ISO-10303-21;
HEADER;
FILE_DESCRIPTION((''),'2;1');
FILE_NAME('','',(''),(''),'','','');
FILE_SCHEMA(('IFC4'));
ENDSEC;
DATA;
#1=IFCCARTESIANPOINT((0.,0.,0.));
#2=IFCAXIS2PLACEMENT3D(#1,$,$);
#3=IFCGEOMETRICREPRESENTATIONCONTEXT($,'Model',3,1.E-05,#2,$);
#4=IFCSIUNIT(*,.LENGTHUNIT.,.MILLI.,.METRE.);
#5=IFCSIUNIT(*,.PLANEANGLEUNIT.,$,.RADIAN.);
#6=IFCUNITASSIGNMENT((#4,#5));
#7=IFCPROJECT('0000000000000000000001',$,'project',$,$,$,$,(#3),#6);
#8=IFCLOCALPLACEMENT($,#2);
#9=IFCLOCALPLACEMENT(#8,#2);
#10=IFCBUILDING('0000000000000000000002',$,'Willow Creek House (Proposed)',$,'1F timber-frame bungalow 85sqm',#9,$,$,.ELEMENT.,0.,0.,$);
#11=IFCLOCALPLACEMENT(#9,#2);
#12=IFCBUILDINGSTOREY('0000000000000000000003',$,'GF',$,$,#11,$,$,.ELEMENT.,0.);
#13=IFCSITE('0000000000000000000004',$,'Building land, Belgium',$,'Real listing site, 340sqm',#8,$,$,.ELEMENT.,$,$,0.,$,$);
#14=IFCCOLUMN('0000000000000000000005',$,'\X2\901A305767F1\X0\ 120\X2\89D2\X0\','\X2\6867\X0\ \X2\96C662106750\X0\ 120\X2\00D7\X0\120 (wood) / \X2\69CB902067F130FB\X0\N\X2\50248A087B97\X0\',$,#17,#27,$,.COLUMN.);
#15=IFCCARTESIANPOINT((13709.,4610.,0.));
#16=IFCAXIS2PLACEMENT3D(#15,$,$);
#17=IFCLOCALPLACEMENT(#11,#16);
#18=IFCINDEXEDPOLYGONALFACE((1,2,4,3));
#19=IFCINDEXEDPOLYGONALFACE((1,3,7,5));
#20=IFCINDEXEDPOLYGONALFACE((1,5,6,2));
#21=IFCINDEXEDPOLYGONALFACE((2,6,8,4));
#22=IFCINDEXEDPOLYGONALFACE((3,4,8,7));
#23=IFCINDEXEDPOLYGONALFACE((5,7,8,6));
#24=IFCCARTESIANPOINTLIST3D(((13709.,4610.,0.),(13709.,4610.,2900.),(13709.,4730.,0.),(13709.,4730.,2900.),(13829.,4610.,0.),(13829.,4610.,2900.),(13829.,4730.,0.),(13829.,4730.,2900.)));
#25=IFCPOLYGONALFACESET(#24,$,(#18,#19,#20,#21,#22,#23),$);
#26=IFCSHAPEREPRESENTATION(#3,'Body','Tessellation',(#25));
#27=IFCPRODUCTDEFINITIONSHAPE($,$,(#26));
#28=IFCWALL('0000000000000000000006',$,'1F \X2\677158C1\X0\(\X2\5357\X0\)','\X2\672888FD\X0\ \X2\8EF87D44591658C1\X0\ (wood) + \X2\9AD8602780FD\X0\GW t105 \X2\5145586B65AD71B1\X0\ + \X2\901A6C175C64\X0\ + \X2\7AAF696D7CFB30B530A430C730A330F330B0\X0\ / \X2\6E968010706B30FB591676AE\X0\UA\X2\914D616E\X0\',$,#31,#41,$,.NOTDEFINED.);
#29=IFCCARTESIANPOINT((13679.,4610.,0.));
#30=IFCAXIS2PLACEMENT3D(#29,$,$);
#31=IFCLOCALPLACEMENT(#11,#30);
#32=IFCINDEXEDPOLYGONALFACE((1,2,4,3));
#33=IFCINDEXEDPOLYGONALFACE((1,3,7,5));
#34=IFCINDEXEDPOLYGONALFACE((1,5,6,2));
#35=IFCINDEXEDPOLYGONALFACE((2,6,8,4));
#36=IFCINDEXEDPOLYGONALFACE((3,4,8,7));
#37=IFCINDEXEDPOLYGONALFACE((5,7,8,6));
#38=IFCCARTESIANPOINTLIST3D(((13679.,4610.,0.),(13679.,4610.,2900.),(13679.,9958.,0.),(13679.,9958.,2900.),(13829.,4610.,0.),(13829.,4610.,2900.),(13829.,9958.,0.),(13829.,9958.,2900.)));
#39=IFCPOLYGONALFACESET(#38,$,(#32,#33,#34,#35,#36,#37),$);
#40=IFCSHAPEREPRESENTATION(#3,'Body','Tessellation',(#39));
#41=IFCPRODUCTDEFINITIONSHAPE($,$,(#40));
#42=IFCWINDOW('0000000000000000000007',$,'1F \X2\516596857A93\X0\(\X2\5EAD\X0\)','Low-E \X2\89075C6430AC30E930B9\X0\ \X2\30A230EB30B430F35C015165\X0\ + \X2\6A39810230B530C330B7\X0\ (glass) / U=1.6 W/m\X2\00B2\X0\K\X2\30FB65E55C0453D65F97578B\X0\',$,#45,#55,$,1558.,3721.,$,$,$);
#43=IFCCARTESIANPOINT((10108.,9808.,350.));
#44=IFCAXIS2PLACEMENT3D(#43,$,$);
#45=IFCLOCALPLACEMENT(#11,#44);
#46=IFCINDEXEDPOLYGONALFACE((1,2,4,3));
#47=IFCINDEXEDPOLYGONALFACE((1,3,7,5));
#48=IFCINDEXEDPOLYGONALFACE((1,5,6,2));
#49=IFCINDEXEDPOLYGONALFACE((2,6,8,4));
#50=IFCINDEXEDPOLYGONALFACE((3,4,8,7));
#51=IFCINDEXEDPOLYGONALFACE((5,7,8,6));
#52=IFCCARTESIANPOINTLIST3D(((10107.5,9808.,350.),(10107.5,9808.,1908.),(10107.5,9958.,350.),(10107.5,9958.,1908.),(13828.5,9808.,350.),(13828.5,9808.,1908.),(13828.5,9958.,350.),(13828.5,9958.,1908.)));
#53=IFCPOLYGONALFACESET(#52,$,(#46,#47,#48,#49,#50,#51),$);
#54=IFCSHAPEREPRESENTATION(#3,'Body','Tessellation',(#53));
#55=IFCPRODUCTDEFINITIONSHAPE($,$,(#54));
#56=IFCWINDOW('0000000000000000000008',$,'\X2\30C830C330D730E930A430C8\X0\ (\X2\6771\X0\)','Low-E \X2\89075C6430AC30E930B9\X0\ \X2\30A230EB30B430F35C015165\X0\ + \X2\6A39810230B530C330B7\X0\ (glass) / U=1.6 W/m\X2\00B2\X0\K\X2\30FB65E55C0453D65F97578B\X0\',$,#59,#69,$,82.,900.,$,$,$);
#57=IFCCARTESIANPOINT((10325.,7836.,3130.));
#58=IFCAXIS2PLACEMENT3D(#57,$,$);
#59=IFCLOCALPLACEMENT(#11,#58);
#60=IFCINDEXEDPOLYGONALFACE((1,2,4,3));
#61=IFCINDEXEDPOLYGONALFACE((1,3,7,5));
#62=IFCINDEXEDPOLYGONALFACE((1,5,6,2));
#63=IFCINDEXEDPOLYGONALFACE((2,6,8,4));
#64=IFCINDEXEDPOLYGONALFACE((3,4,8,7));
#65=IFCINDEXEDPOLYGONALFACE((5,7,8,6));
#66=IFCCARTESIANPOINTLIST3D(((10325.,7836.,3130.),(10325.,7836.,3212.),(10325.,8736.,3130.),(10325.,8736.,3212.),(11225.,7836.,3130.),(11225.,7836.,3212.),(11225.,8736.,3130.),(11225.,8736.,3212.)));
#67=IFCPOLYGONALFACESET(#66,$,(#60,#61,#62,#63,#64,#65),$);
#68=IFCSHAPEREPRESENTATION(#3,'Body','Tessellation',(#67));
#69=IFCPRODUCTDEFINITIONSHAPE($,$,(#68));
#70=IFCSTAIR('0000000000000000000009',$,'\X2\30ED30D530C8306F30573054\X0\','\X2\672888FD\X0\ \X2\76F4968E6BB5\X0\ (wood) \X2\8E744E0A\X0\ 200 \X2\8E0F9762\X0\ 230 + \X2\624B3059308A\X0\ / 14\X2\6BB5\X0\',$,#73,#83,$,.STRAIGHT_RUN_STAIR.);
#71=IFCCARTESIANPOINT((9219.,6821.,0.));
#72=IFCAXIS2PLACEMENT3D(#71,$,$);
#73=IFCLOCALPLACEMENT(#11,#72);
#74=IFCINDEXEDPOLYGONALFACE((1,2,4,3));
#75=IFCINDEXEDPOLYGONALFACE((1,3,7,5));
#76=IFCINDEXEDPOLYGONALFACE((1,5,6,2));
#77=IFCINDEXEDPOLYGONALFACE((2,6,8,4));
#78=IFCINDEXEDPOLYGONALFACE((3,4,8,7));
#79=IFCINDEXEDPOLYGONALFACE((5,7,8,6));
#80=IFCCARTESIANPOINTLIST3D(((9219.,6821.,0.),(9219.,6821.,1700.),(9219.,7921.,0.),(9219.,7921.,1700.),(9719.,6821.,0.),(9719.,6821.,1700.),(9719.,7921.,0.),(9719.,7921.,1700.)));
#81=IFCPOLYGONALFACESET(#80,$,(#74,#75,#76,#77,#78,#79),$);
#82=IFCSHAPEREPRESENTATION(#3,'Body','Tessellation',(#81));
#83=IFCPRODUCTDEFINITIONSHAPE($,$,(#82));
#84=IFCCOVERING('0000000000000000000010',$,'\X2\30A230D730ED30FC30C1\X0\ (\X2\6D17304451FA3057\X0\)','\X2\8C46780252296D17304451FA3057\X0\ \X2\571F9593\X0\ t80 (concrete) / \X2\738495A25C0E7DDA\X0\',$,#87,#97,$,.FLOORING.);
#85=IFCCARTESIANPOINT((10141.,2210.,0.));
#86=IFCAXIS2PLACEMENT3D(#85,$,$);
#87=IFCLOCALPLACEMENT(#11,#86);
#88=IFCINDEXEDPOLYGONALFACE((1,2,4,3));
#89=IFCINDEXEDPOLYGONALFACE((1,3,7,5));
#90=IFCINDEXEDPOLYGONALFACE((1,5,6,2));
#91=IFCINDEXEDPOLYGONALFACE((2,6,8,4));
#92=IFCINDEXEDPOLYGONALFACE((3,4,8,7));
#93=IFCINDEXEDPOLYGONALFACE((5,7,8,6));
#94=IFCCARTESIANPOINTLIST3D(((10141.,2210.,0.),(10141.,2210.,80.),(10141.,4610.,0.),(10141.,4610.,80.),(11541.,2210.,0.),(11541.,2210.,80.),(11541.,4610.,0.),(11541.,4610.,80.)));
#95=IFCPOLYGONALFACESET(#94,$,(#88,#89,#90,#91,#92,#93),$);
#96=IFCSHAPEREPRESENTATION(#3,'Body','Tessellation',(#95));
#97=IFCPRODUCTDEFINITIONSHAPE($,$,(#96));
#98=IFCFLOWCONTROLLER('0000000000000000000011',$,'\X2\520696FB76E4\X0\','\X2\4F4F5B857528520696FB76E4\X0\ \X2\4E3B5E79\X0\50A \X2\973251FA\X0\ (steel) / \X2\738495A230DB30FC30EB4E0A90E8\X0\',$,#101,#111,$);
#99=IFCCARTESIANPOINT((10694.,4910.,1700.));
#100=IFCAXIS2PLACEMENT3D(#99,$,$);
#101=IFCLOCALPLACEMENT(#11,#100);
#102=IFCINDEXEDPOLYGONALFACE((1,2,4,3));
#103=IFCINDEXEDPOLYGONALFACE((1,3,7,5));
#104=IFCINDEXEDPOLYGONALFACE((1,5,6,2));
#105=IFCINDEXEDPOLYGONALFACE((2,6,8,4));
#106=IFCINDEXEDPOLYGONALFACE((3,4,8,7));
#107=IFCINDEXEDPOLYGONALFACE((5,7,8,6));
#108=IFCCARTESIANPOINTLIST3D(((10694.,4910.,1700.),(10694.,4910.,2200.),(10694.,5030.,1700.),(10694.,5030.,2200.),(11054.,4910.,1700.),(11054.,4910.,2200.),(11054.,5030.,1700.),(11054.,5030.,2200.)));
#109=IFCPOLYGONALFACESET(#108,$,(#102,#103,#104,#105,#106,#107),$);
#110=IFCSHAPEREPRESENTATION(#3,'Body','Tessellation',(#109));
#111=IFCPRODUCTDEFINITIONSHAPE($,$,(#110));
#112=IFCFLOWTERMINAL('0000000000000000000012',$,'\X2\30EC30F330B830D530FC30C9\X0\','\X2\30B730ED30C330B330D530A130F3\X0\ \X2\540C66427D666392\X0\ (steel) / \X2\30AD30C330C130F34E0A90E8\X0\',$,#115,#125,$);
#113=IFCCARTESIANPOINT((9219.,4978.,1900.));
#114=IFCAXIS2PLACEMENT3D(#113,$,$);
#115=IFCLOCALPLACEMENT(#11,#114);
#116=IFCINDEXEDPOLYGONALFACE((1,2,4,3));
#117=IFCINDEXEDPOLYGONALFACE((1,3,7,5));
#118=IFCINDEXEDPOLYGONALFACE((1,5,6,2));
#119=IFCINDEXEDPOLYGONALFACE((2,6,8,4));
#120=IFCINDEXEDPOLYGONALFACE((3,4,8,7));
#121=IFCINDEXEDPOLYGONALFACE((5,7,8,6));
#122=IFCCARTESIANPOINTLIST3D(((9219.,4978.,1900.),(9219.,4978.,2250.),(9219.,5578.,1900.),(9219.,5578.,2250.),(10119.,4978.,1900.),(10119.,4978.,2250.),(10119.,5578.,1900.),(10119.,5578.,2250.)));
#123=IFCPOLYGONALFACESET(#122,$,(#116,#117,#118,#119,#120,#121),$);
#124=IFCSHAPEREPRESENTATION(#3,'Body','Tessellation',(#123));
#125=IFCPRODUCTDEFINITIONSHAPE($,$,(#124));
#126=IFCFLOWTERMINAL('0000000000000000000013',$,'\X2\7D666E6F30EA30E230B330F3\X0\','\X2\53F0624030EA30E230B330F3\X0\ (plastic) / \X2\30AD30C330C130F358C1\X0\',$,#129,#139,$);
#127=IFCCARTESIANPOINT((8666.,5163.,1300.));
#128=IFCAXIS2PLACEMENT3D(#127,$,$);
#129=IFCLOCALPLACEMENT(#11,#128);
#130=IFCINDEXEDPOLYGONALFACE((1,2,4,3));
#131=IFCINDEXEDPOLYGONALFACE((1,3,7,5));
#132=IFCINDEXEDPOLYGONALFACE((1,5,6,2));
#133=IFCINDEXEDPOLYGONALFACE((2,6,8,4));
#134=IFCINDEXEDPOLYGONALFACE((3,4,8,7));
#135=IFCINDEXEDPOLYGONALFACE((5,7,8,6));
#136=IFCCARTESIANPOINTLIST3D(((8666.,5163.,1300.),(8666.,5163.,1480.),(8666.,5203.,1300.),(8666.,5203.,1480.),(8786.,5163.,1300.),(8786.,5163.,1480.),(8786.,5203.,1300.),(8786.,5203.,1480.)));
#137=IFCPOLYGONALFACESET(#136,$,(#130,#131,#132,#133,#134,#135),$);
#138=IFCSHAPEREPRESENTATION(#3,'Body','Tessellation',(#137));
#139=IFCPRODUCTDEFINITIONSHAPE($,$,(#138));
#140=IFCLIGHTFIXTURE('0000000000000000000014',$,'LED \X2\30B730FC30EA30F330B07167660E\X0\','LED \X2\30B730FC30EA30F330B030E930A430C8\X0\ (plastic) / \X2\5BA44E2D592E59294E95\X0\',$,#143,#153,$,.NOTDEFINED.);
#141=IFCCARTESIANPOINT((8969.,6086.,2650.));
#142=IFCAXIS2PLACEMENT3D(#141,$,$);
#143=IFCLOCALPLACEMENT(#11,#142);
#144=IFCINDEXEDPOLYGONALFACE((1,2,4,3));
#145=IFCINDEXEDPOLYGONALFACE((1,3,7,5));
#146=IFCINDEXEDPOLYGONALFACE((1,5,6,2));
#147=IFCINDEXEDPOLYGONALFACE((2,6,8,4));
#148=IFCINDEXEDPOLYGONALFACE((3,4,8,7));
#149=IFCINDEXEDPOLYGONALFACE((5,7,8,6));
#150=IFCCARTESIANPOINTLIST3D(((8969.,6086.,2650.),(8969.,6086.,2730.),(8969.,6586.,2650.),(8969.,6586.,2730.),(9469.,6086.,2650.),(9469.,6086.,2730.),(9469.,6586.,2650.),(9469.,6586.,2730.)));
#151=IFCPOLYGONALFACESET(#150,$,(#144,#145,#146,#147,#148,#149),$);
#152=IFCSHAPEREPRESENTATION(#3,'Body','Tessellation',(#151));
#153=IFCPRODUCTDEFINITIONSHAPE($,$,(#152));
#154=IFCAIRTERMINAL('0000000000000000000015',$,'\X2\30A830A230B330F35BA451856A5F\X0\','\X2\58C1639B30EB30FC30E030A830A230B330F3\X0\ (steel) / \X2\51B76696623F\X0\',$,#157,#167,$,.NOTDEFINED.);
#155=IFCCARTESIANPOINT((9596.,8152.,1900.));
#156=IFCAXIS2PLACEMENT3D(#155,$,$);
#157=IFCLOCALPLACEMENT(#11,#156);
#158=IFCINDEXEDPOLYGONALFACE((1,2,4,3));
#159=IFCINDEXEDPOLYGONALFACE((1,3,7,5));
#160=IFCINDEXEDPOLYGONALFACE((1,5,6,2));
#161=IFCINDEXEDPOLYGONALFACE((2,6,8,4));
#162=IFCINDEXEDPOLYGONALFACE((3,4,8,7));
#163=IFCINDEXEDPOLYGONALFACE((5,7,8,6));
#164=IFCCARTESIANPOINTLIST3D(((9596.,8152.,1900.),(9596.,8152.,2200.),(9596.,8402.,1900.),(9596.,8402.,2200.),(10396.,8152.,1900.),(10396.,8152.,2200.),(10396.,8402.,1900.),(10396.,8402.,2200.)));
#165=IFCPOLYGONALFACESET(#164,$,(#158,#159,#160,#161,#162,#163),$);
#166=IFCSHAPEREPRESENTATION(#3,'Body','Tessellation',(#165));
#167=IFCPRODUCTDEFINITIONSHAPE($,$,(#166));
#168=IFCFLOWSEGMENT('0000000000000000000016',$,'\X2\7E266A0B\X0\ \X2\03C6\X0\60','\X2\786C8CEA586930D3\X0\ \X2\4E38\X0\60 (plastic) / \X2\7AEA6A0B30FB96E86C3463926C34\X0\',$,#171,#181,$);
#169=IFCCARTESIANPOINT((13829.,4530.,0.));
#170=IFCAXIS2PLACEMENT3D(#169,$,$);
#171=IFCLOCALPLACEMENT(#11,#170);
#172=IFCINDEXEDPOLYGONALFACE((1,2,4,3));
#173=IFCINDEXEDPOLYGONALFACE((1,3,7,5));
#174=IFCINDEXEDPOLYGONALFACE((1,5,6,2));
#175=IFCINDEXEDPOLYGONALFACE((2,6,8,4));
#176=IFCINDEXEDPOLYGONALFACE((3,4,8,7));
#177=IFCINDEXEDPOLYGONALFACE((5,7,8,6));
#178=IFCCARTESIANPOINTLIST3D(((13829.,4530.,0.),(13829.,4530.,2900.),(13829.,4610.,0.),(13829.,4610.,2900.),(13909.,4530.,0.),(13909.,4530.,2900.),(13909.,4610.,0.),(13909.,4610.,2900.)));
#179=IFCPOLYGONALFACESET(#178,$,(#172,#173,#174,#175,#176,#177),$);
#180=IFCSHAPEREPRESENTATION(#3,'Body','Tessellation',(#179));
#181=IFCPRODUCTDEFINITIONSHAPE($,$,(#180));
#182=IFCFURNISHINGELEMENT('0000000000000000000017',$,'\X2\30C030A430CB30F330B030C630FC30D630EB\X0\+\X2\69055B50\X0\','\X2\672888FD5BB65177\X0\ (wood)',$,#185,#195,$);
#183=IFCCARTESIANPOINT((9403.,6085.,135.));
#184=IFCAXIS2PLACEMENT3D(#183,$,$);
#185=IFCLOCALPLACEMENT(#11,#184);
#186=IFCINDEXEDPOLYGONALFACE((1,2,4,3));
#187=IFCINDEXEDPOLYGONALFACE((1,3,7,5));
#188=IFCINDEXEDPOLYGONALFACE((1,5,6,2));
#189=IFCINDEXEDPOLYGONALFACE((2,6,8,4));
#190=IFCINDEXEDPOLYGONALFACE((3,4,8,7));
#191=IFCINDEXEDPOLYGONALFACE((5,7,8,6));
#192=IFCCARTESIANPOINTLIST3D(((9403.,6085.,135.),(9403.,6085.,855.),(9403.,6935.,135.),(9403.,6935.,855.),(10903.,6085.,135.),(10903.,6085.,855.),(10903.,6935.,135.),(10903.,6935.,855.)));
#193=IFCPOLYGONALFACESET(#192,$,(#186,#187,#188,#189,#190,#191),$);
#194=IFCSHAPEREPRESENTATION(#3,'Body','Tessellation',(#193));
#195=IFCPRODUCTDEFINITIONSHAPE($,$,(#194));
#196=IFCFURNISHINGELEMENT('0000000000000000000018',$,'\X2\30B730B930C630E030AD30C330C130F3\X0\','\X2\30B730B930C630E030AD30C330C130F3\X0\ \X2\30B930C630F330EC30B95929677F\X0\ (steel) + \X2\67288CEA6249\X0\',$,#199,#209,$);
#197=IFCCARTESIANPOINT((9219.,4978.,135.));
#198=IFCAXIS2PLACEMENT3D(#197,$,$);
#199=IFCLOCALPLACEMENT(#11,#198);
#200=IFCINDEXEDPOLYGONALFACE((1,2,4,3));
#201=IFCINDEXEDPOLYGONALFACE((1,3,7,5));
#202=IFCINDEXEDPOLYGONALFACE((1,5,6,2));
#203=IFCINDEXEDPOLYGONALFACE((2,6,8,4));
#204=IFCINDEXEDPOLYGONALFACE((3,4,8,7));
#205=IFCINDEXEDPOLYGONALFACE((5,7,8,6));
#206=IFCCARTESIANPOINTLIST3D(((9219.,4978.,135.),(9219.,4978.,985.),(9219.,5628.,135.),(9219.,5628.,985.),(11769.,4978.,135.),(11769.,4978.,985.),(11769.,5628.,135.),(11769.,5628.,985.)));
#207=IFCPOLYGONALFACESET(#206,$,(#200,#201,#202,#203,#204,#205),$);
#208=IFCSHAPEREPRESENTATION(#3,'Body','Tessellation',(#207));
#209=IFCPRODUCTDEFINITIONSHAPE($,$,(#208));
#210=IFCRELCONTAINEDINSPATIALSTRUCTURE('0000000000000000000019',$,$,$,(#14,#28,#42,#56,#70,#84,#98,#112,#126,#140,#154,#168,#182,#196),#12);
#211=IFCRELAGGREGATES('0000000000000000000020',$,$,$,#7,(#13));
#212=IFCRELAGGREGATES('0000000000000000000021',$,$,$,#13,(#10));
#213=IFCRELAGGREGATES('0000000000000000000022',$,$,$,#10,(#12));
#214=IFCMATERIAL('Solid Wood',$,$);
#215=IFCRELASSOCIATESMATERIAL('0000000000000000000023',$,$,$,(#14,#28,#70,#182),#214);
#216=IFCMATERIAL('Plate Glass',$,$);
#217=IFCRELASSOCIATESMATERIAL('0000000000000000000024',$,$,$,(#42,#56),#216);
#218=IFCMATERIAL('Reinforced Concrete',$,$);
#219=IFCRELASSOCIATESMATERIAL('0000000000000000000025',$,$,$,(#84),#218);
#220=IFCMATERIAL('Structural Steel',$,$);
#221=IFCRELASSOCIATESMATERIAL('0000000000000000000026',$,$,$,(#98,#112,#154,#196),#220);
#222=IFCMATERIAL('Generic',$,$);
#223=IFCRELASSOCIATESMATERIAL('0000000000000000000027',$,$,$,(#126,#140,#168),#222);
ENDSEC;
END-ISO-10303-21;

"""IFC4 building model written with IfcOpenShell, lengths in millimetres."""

from ifc_helpers import new_model, si_unit, frame, frame_2d, origin, place, context, project, spatial, rectangle, extrude, material, element, fill, save


model = new_model("IFC4")

# Units and contexts
model_context = context("Model", 3, precision=1e-05, world=origin())
ifc_project = project(units=[si_unit("LENGTHUNIT", "METRE", prefix="MILLI"), si_unit("PLANEANGLEUNIT", "RADIAN")], contexts=[model_context])

# Site, building, storey
site_placement = place(None, origin())
site = spatial("IfcSite", under=ifc_project, at=site_placement, Name="Building land, Belgium", ObjectType="Real listing site, 340sqm", CompositionType="ELEMENT", RefElevation=0.0)
building_placement = place(site_placement, origin())
building = spatial("IfcBuilding", under=site, at=building_placement, Name="Willow Creek House (Proposed)", ObjectType="1F timber-frame bungalow 85sqm", CompositionType="ELEMENT", ElevationOfRefHeight=0.0, ElevationOfTerrain=0.0)
storey_placement = place(building_placement, origin())
storey = spatial("IfcBuildingStorey", under=building, at=storey_placement, Name="GF", CompositionType="ELEMENT", Elevation=0.0)

# Column
ifc_material_1 = material(Name="Solid Wood")
column_1_placement = place(storey_placement, frame((13709.0, 4610.0, 0.0)))
element("IfcColumn", 1, at=column_1_placement, inside=storey, material=ifc_material_1, Name="通し柱 120角", Description="桧 集成材 120×120 (wood) / 構造柱・N値計算", PredefinedType="COLUMN", context=model_context, shape_type="SweptSolid", body=[
    extrude(rectangle(XDim=120.0, YDim=120.0, at=frame_2d((60.0, 60.0))), frame((13709.0, 4610.0, 0.0)), (0.0, 0.0, 1.0), 2900.0),
])

# Wall, opening, window
wall_1_placement = place(storey_placement, frame((13679.0, 4610.0, 0.0)))
wall_1 = element("IfcWall", 2, at=wall_1_placement, inside=storey, material=ifc_material_1, Name="1F 東壁(南)", Description="木製 軸組外壁 (wood) + 高性能GW t105 充填断熱 + 通気層 + 窯業系サイディング / 準耐火・外皮UA配慮", PredefinedType="NOTDEFINED", context=model_context, shape_type="SweptSolid", body=[
    extrude(rectangle(XDim=150.0, YDim=5348.0, at=frame_2d((75.0, 2674.0))), frame((13679.0, 4610.0, 0.0)), (0.0, 0.0, 1.0), 2900.0),
])
opening_placement = place(storey_placement, frame((10108.0, 9808.0, 350.0)))
opening = element("IfcOpeningElement", 3, at=opening_placement, cuts=wall_1, PredefinedType="NOTDEFINED", context=model_context, shape_type="SweptSolid", body=[
    extrude(rectangle(XDim=3721.0, YDim=150.0, at=frame_2d((1860.0, 75.0))), frame((10108.0, 9808.0, 350.0)), (0.0, 0.0, 1.0), 1558.0),
])
ifc_material_2 = material(Name="Plate Glass")
window_1_placement = place(storey_placement, frame((10108.0, 9808.0, 350.0)))
window_1 = element("IfcWindow", 4, at=window_1_placement, inside=storey, material=ifc_material_2, Name="1F 入隅窓(庭)", Description="Low-E 複層ガラス アルゴン封入 + 樹脂サッシ (glass) / U=1.6 W/m²K・日射取得型", OverallHeight=1558.0, OverallWidth=3721.0, context=model_context, shape_type="SweptSolid", body=[
    extrude(rectangle(XDim=3721.0, YDim=150.0, at=frame_2d((1860.0, 75.0))), frame((10108.0, 9808.0, 350.0)), (0.0, 0.0, 1.0), 1558.0),
])
fill(opening, window_1)

# Window
window_2_placement = place(storey_placement, frame((10325.0, 7836.0, 3130.0)))
element("IfcWindow", 5, at=window_2_placement, inside=storey, material=ifc_material_2, Name="トップライト (東)", Description="Low-E 複層ガラス アルゴン封入 + 樹脂サッシ (glass) / U=1.6 W/m²K・日射取得型", OverallHeight=82.0, OverallWidth=900.0, context=model_context, shape_type="SweptSolid", body=[
    extrude(rectangle(XDim=900.0, YDim=900.0, at=frame_2d((450.0, 450.0))), frame((10325.0, 7836.0, 3130.0)), (0.0, 0.0, 1.0), 82.0),
])

# Stair
stair_placement = place(storey_placement, frame((9219.0, 6821.0, 0.0)))
element("IfcStair", 6, at=stair_placement, inside=storey, material=ifc_material_1, Name="ロフトはしご", Description="木製 直階段 (wood) 蹴上 200 踏面 230 + 手すり / 14段", PredefinedType="STRAIGHT_RUN_STAIR", context=model_context, shape_type="SweptSolid", body=[
    extrude(rectangle(XDim=500.0, YDim=1100.0, at=frame_2d((250.0, 550.0))), frame((9219.0, 6821.0, 0.0)), (0.0, 0.0, 1.0), 1700.0),
])

# Covering
ifc_material_3 = material(Name="Reinforced Concrete")
covering_placement = place(storey_placement, frame((10141.0, 2210.0, 0.0)))
element("IfcCovering", 7, at=covering_placement, inside=storey, material=ifc_material_3, Name="アプローチ (洗い出し)", Description="豆砂利洗い出し 土間 t80 (concrete) / 玄関導線", PredefinedType="FLOORING", context=model_context, shape_type="SweptSolid", body=[
    extrude(rectangle(XDim=1400.0, YDim=2400.0, at=frame_2d((700.0, 1200.0))), frame((10141.0, 2210.0, 0.0)), (0.0, 0.0, 1.0), 80.0),
])

# Flow controller
ifc_material_4 = material(Name="Structural Steel")
flow_controller_placement = place(storey_placement, frame((10694.0, 4910.0, 1700.0)))
element("IfcFlowController", 8, at=flow_controller_placement, inside=storey, material=ifc_material_4, Name="分電盤", Description="住宅用分電盤 主幹50A 露出 (steel) / 玄関ホール上部", context=model_context, shape_type="SweptSolid", body=[
    extrude(rectangle(XDim=360.0, YDim=120.0, at=frame_2d((180.0, 60.0))), frame((10694.0, 4910.0, 1700.0)), (0.0, 0.0, 1.0), 500.0),
])

# Flow terminals
flow_terminal_1_placement = place(storey_placement, frame((9219.0, 4978.0, 1900.0)))
element("IfcFlowTerminal", 9, at=flow_terminal_1_placement, inside=storey, material=ifc_material_4, Name="レンジフード", Description="シロッコファン 同時給排 (steel) / キッチン上部", context=model_context, shape_type="SweptSolid", body=[
    extrude(rectangle(XDim=900.0, YDim=600.0, at=frame_2d((450.0, 300.0))), frame((9219.0, 4978.0, 1900.0)), (0.0, 0.0, 1.0), 350.0),
])
ifc_material_5 = material(Name="Generic")
flow_terminal_2_placement = place(storey_placement, frame((8666.0, 5163.0, 1300.0)))
element("IfcFlowTerminal", 10, at=flow_terminal_2_placement, inside=storey, material=ifc_material_5, Name="給湯リモコン", Description="台所リモコン (plastic) / キッチン壁", context=model_context, shape_type="SweptSolid", body=[
    extrude(rectangle(XDim=120.0, YDim=40.0, at=frame_2d((60.0, 20.0))), frame((8666.0, 5163.0, 1300.0)), (0.0, 0.0, 1.0), 180.0),
])

# Light fixture
light_fixture_placement = place(storey_placement, frame((8969.0, 6086.0, 2650.0)))
element("IfcLightFixture", 11, at=light_fixture_placement, inside=storey, material=ifc_material_5, Name="LED シーリング照明", Description="LED シーリングライト (plastic) / 室中央天井", PredefinedType="NOTDEFINED", context=model_context, shape_type="SweptSolid", body=[
    extrude(rectangle(XDim=500.0, YDim=500.0, at=frame_2d((250.0, 250.0))), frame((8969.0, 6086.0, 2650.0)), (0.0, 0.0, 1.0), 80.0),
])

# Air terminal
air_terminal_placement = place(storey_placement, frame((9596.0, 8152.0, 1900.0)))
element("IfcAirTerminal", 12, at=air_terminal_placement, inside=storey, material=ifc_material_4, Name="エアコン室内機", Description="壁掛ルームエアコン (steel) / 冷暖房", PredefinedType="NOTDEFINED", context=model_context, shape_type="SweptSolid", body=[
    extrude(rectangle(XDim=800.0, YDim=250.0, at=frame_2d((400.0, 125.0))), frame((9596.0, 8152.0, 1900.0)), (0.0, 0.0, 1.0), 300.0),
])

# Flow segment
flow_segment_placement = place(storey_placement, frame((13829.0, 4530.0, 0.0)))
element("IfcFlowSegment", 13, at=flow_segment_placement, inside=storey, material=ifc_material_5, Name="縦樋 φ60", Description="硬質塩ビ 丸60 (plastic) / 竪樋・雨水排水", context=model_context, shape_type="SweptSolid", body=[
    extrude(rectangle(XDim=80.0, YDim=80.0, at=frame_2d((40.0, 40.0))), frame((13829.0, 4530.0, 0.0)), (0.0, 0.0, 1.0), 2900.0),
])

# Furnishing elements
furnishing_1_placement = place(storey_placement, frame((9403.0, 6085.0, 135.0)))
element("IfcFurnishingElement", 14, at=furnishing_1_placement, inside=storey, material=ifc_material_1, Name="ダイニングテーブル+椅子", Description="木製家具 (wood)", context=model_context, shape_type="SweptSolid", body=[
    extrude(rectangle(XDim=1500.0, YDim=850.0, at=frame_2d((750.0, 425.0))), frame((9403.0, 6085.0, 135.0)), (0.0, 0.0, 1.0), 720.0),
])
furnishing_2_placement = place(storey_placement, frame((9219.0, 4978.0, 135.0)))
element("IfcFurnishingElement", 15, at=furnishing_2_placement, inside=storey, material=ifc_material_4, Name="システムキッチン", Description="システムキッチン ステンレス天板 (steel) + 木質扉", context=model_context, shape_type="SweptSolid", body=[
    extrude(rectangle(XDim=2550.0, YDim=650.0, at=frame_2d((1275.0, 325.0))), frame((9219.0, 4978.0, 135.0)), (0.0, 0.0, 1.0), 850.0),
])

save(model, "model.ifc")
